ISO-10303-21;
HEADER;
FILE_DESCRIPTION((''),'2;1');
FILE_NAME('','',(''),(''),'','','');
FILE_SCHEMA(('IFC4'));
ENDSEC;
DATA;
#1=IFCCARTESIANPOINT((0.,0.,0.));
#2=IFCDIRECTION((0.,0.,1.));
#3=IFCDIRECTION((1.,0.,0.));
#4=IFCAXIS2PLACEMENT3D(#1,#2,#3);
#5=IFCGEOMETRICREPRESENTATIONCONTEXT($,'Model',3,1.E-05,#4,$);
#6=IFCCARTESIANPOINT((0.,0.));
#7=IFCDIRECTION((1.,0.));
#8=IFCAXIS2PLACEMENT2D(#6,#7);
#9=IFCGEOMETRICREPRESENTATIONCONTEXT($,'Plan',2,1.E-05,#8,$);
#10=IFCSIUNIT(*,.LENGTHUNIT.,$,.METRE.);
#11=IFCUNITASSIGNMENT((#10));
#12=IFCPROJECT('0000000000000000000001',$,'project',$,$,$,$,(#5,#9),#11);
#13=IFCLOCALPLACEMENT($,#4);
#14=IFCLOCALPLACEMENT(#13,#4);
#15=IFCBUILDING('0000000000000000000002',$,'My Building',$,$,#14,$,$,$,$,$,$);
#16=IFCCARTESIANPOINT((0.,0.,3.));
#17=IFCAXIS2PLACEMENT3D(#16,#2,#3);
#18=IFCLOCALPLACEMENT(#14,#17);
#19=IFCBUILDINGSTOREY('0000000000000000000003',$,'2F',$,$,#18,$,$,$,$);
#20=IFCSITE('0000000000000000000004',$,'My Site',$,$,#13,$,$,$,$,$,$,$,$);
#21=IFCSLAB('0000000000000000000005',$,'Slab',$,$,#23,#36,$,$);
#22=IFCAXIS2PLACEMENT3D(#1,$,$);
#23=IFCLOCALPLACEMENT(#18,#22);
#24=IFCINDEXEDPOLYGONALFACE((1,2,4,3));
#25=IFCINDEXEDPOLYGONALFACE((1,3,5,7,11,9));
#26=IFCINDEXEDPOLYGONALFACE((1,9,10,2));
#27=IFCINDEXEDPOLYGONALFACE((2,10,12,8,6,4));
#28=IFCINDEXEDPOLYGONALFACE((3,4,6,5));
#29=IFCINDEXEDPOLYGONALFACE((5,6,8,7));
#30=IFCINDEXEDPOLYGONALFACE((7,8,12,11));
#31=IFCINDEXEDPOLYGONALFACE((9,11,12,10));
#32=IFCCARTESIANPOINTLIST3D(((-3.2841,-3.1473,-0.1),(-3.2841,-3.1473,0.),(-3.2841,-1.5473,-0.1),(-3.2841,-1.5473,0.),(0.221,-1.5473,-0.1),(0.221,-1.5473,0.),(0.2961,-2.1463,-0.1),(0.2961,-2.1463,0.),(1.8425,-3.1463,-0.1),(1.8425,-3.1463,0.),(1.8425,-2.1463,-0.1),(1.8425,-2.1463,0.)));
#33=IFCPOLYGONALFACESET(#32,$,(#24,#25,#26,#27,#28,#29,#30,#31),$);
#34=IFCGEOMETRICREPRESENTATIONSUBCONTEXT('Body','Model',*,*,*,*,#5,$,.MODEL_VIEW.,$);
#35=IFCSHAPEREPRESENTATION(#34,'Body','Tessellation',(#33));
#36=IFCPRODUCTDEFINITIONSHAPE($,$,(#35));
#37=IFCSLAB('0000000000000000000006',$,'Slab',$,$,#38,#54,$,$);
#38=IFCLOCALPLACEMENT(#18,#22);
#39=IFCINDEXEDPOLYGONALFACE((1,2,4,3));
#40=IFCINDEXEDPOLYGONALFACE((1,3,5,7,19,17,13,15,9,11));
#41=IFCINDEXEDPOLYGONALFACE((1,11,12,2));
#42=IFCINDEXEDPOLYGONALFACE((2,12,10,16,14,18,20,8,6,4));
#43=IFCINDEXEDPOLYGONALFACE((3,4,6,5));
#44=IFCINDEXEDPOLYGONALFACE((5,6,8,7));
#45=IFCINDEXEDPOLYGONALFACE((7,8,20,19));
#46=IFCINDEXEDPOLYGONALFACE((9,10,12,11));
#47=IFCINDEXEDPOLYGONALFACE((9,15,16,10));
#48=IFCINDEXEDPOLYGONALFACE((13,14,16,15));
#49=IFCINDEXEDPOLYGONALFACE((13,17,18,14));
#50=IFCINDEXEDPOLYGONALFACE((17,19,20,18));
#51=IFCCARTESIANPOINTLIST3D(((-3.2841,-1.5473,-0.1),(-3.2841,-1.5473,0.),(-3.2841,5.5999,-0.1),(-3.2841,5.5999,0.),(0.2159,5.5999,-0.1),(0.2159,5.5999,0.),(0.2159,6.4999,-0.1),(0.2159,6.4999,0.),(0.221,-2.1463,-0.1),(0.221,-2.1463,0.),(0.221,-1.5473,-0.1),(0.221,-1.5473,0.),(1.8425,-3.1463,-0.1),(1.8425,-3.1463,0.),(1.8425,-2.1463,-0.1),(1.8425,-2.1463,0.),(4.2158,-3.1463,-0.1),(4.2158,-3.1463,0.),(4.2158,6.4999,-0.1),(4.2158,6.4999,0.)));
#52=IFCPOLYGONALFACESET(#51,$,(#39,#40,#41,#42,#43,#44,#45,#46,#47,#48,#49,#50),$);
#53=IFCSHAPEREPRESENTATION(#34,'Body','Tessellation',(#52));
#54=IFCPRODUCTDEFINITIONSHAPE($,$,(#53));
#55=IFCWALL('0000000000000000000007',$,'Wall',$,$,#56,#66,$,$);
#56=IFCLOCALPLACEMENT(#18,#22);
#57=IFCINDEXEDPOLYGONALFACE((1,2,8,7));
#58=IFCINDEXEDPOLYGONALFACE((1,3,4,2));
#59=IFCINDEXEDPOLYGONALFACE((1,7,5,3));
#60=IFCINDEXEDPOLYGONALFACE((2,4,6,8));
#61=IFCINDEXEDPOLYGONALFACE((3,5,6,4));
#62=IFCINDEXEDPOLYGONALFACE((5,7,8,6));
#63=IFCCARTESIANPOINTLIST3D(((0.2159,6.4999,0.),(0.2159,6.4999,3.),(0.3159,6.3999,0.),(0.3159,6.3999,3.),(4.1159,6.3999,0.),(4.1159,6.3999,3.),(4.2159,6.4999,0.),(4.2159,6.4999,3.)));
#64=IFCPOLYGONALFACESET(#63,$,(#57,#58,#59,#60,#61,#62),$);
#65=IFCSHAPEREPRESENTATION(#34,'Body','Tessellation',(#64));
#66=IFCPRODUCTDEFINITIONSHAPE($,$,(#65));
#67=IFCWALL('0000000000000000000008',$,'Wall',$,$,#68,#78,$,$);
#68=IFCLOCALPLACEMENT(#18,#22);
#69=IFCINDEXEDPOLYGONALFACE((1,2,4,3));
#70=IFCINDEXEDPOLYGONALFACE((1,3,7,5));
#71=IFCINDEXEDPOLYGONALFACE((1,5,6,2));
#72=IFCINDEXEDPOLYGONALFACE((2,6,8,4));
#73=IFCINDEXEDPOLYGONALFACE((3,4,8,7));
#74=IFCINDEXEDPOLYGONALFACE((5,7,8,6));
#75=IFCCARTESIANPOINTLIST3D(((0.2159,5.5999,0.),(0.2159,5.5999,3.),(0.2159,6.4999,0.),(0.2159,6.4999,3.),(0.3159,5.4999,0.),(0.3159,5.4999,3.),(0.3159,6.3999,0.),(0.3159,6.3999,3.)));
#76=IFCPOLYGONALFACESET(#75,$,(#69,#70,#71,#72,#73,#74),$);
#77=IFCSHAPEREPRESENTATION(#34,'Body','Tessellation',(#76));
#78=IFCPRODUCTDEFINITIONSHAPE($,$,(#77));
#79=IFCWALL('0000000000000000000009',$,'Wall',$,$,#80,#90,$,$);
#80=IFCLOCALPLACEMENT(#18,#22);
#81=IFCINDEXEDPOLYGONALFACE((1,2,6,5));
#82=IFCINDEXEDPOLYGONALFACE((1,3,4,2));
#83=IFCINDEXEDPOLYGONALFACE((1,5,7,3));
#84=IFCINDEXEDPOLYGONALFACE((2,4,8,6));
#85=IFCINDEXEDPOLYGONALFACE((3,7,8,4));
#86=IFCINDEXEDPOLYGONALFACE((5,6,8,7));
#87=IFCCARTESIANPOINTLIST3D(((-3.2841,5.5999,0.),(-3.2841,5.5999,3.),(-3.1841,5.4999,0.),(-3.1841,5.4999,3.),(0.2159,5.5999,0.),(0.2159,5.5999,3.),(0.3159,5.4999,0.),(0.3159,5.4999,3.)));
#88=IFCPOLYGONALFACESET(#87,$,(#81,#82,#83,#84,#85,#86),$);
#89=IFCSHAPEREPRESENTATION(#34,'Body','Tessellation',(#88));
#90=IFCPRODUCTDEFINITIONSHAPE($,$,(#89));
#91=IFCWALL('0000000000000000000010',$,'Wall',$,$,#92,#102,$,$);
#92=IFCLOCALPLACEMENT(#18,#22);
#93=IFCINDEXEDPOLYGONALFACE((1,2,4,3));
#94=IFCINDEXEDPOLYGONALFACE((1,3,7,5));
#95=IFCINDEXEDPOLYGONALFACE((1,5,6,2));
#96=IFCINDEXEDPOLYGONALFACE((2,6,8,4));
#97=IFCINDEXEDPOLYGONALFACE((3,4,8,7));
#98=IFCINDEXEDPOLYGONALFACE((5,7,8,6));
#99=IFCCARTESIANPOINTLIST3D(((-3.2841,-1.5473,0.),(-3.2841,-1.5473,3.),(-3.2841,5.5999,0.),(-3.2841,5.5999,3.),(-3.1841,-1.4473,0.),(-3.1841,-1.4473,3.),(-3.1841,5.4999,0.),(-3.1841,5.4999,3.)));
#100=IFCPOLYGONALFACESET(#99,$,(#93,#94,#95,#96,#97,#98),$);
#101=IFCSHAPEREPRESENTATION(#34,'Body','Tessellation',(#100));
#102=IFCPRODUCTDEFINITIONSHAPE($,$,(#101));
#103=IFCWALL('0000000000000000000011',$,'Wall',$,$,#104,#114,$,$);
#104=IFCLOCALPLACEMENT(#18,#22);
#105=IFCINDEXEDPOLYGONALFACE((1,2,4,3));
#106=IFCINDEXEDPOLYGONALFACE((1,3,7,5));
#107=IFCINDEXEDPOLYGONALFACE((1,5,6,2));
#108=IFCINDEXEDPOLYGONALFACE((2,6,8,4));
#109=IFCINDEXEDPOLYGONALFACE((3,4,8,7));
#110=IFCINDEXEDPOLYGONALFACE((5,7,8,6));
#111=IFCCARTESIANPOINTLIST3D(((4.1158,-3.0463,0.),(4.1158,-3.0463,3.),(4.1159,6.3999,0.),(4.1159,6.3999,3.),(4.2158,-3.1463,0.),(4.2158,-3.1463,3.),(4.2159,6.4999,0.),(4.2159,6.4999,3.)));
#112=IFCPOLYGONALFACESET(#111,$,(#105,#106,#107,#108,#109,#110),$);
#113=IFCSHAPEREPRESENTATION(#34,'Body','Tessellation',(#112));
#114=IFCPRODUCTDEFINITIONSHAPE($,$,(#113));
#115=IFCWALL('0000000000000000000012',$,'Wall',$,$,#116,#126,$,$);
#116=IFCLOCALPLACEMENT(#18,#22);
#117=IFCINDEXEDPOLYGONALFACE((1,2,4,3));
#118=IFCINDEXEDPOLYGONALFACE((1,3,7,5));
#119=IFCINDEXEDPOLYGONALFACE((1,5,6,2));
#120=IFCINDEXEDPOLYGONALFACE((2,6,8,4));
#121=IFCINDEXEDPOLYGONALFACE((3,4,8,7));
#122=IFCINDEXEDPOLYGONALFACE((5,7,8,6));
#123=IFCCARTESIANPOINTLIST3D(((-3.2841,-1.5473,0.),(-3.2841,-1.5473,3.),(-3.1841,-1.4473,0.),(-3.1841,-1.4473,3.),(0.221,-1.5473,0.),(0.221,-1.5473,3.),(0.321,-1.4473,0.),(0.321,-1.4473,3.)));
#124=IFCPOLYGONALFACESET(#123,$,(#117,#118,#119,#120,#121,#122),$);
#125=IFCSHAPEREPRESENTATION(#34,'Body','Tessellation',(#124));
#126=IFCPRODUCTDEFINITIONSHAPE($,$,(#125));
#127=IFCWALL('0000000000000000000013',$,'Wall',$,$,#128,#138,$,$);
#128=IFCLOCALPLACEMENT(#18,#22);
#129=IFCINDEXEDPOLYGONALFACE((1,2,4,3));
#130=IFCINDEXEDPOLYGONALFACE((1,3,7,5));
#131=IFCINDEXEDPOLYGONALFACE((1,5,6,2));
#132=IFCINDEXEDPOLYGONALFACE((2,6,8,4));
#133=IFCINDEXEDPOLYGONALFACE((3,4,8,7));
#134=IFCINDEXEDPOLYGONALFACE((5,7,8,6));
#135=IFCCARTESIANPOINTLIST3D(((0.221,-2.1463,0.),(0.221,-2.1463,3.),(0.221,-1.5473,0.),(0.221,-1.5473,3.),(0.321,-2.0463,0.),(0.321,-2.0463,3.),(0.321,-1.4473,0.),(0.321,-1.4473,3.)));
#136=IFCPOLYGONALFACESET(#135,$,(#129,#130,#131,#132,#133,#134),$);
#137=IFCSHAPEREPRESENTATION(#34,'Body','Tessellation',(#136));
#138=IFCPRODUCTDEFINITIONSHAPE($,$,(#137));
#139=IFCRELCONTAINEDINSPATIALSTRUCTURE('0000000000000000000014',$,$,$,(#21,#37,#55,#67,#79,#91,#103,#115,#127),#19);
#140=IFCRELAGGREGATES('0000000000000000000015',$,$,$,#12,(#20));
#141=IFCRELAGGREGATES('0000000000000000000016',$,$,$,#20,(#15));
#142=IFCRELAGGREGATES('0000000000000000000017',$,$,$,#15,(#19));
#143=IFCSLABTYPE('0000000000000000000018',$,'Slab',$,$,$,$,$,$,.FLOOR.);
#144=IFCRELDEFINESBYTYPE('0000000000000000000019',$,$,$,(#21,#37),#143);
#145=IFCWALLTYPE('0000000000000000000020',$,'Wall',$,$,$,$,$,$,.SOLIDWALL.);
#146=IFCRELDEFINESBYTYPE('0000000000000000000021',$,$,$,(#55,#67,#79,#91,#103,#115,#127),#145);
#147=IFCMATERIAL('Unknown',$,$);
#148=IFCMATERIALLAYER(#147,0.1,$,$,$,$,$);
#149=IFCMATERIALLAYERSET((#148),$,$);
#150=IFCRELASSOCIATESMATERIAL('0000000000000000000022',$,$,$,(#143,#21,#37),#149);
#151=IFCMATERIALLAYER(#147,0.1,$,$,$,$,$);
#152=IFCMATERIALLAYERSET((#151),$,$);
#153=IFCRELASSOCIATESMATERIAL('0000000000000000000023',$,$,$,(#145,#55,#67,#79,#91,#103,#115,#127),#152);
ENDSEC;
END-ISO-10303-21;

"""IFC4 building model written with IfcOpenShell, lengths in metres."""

from ifc_helpers import new_model, si_unit, frame, origin_with_axes, origin_2d_with_axis, place, context, subcontext, project, spatial, line, indexed_curve, outline, extrude, material, layer, layer_set, layer_usage, type_object, element, save


model = new_model("IFC4")

# Units and contexts
model_context = context("Model", 3, precision=1e-05, world=origin_with_axes())
plan_context = context("Plan", 2, precision=1e-05, world=origin_2d_with_axis())
body_context_1 = subcontext(model_context, "Body", "Model", "MODEL_VIEW")
ifc_project = project(units=[si_unit("LENGTHUNIT", "METRE")], contexts=[model_context, plan_context])

# Site, building, storey
site_placement = place(None, origin_with_axes())
site = spatial("IfcSite", under=ifc_project, at=site_placement, Name="My Site")
building_placement = place(site_placement, origin_with_axes())
building = spatial("IfcBuilding", under=site, at=building_placement, Name="My Building")
storey_placement = place(building_placement, frame((0.0, 0.0, 3.0), z_axis=(0.0, 0.0, 1.0), x_axis=(1.0, 0.0, 0.0)))
storey = spatial("IfcBuildingStorey", under=building, at=storey_placement, Name="2F")

# Slabs
ifc_material = material(Name="Unknown")
ifc_layer_1 = layer(ifc_material, 0.1)
ifc_layer_set_1 = layer_set([ifc_layer_1])
ifc_layer_usage_1 = layer_usage(ifc_layer_set_1, "AXIS3", "POSITIVE", -0.1)
slab_type = type_object("IfcSlabType", Name="Slab", PredefinedType="FLOOR", material=ifc_layer_set_1)
slab_1_placement = place(storey_placement, frame((-3.2841, -1.5473, 0.0), z_axis=(0.0, 0.0, 1.0), x_axis=(1.0, 0.0, 0.0)))
element("IfcSlab", 1, at=slab_1_placement, inside=storey, type_object=slab_type, material=ifc_layer_usage_1, Name="Slab", context=body_context_1, shape_type="SweptSolid", body=[
    extrude(outline(indexed_curve([(0.0, 0.0), (0.0, -1.6), (5.1266, -1.599), (5.1266, -0.599), (3.5803, -0.599), (3.5052, 0.0), (0.0, 0.0)])), frame((0.0, 0.0, -0.1), z_axis=(0.0, 0.0, 1.0), x_axis=(1.0, 0.0, 0.0)), (0.0, 0.0, 1.0), 0.1),
])
ifc_layer_usage_2 = layer_usage(ifc_layer_set_1, "AXIS3", "POSITIVE", -0.1)
slab_2_placement = place(storey_placement, frame((4.2158, 6.4999, 0.0), z_axis=(0.0, 0.0, 1.0), x_axis=(1.0, 0.0, 0.0)))
element("IfcSlab", 2, at=slab_2_placement, inside=storey, type_object=slab_type, material=ifc_layer_usage_2, Name="Slab", context=body_context_1, shape_type="SweptSolid", body=[
    extrude(outline(indexed_curve([(0.0, 0.0), (-4.0, 0.0), (-4.0, -0.9), (-7.5, -0.9), (-7.5, -8.0471), (-3.9948, -8.0471), (-3.9948, -8.6461), (-2.3734, -8.6461), (-2.3734, -9.6461), (0.0, -9.6461), (0.0, 0.0)])), frame((0.0, 0.0, -0.1), z_axis=(0.0, 0.0, 1.0), x_axis=(1.0, 0.0, 0.0)), (0.0, 0.0, 1.0), 0.1),
])

# Walls
ifc_layer_2 = layer(ifc_material, 0.1)
ifc_layer_set_2 = layer_set([ifc_layer_2])
ifc_layer_usage_3 = layer_usage(ifc_layer_set_2, "AXIS2", "POSITIVE", 0.0)
wall_type = type_object("IfcWallType", Name="Wall", PredefinedType="SOLIDWALL", material=ifc_layer_set_2)
wall_1_placement = place(storey_placement, frame((4.2159, 6.4999, 0.0), z_axis=(0.0, 0.0, 1.0), x_axis=(-1.0, 0.0, 0.0)))
element("IfcWall", 3, at=wall_1_placement, inside=storey, type_object=wall_type, material=ifc_layer_usage_3, Name="Wall", context=body_context_1, shape_type="SweptSolid", body=[
    extrude(outline(indexed_curve([(0.0, 0.0), (0.1, 0.1), (3.9, 0.1), (4.0, 0.0)], segments=[line(1, 2, 3, 4, 1)])), origin_with_axes(), (0.0, 0.0, 1.0), 3.0),
])
ifc_layer_usage_4 = layer_usage(ifc_layer_set_2, "AXIS2", "POSITIVE", 0.0)
wall_2_placement = place(storey_placement, frame((0.2159, 6.4999, 0.0), z_axis=(0.0, 0.0, 1.0), x_axis=(0.0, -1.0, 0.0)))
element("IfcWall", 4, at=wall_2_placement, inside=storey, type_object=wall_type, material=ifc_layer_usage_4, Name="Wall", context=body_context_1, shape_type="SweptSolid", body=[
    extrude(outline(indexed_curve([(0.0, 0.0), (0.1, 0.1), (1.0, 0.1), (0.9, 0.0)], segments=[line(1, 2, 3, 4, 1)])), origin_with_axes(), (0.0, 0.0, 1.0), 3.0),
])
ifc_layer_usage_5 = layer_usage(ifc_layer_set_2, "AXIS2", "POSITIVE", 0.0)
wall_3_placement = place(storey_placement, frame((0.2159, 5.5999, 0.0), z_axis=(0.0, 0.0, 1.0), x_axis=(-1.0, 0.0, 0.0)))
element("IfcWall", 5, at=wall_3_placement, inside=storey, type_object=wall_type, material=ifc_layer_usage_5, Name="Wall", context=body_context_1, shape_type="SweptSolid", body=[
    extrude(outline(indexed_curve([(0.0, 0.0), (-0.1, 0.1), (3.4, 0.1), (3.5, 0.0)], segments=[line(1, 2, 3, 4, 1)])), origin_with_axes(), (0.0, 0.0, 1.0), 3.0),
])
ifc_layer_usage_6 = layer_usage(ifc_layer_set_2, "AXIS2", "POSITIVE", 0.0)
wall_4_placement = place(storey_placement, frame((-3.2841, 5.5999, 0.0), z_axis=(0.0, 0.0, 1.0), x_axis=(0.0, -1.0, 0.0)))
element("IfcWall", 6, at=wall_4_placement, inside=storey, type_object=wall_type, material=ifc_layer_usage_6, Name="Wall", context=body_context_1, shape_type="SweptSolid", body=[
    extrude(outline(indexed_curve([(0.0, 0.0), (0.1, 0.1), (7.0471, 0.1), (7.1471, 0.0)], segments=[line(1, 2, 3, 4, 1)])), origin_with_axes(), (0.0, 0.0, 1.0), 3.0),
])
ifc_layer_usage_7 = layer_usage(ifc_layer_set_2, "AXIS2", "POSITIVE", 0.0)
wall_5_placement = place(storey_placement, frame((4.2158, -3.1463, 0.0), z_axis=(0.0, 0.0, 1.0), x_axis=(0.0, 1.0, 0.0)))
element("IfcWall", 7, at=wall_5_placement, inside=storey, type_object=wall_type, material=ifc_layer_usage_7, Name="Wall", context=body_context_1, shape_type="SweptSolid", body=[
    extrude(outline(indexed_curve([(0.0, 0.0), (0.1, 0.1), (9.5461, 0.1), (9.6461, 0.0)], segments=[line(1, 2, 3, 4, 1)])), origin_with_axes(), (0.0, 0.0, 1.0), 3.0),
])
ifc_layer_usage_8 = layer_usage(ifc_layer_set_2, "AXIS2", "POSITIVE", 0.0)
wall_6_placement = place(storey_placement, frame((-3.2841, -1.5473, 0.0), z_axis=(0.0, 0.0, 1.0), x_axis=(1.0, 0.0, 0.0)))
element("IfcWall", 8, at=wall_6_placement, inside=storey, type_object=wall_type, material=ifc_layer_usage_8, Name="Wall", context=body_context_1, shape_type="SweptSolid", body=[
    extrude(outline(indexed_curve([(0.0, 0.0), (0.1, 0.1), (3.6052, 0.1), (3.5052, 0.0)], segments=[line(1, 2, 3, 4, 1)])), origin_with_axes(), (0.0, 0.0, 1.0), 3.0),
])
ifc_layer_usage_9 = layer_usage(ifc_layer_set_2, "AXIS2", "POSITIVE", 0.0)
wall_7_placement = place(storey_placement, frame((0.221, -1.5473, 0.0), z_axis=(0.0, 0.0, 1.0), x_axis=(0.0, -1.0, 0.0)))
element("IfcWall", 9, at=wall_7_placement, inside=storey, type_object=wall_type, material=ifc_layer_usage_9, Name="Wall", context=body_context_1, shape_type="SweptSolid", body=[
    extrude(outline(indexed_curve([(0.0, 0.0), (-0.1, 0.1), (0.499, 0.1), (0.599, 0.0)], segments=[line(1, 2, 3, 4, 1)])), origin_with_axes(), (0.0, 0.0, 1.0), 3.0),
])

save(model, "model.ifc")
